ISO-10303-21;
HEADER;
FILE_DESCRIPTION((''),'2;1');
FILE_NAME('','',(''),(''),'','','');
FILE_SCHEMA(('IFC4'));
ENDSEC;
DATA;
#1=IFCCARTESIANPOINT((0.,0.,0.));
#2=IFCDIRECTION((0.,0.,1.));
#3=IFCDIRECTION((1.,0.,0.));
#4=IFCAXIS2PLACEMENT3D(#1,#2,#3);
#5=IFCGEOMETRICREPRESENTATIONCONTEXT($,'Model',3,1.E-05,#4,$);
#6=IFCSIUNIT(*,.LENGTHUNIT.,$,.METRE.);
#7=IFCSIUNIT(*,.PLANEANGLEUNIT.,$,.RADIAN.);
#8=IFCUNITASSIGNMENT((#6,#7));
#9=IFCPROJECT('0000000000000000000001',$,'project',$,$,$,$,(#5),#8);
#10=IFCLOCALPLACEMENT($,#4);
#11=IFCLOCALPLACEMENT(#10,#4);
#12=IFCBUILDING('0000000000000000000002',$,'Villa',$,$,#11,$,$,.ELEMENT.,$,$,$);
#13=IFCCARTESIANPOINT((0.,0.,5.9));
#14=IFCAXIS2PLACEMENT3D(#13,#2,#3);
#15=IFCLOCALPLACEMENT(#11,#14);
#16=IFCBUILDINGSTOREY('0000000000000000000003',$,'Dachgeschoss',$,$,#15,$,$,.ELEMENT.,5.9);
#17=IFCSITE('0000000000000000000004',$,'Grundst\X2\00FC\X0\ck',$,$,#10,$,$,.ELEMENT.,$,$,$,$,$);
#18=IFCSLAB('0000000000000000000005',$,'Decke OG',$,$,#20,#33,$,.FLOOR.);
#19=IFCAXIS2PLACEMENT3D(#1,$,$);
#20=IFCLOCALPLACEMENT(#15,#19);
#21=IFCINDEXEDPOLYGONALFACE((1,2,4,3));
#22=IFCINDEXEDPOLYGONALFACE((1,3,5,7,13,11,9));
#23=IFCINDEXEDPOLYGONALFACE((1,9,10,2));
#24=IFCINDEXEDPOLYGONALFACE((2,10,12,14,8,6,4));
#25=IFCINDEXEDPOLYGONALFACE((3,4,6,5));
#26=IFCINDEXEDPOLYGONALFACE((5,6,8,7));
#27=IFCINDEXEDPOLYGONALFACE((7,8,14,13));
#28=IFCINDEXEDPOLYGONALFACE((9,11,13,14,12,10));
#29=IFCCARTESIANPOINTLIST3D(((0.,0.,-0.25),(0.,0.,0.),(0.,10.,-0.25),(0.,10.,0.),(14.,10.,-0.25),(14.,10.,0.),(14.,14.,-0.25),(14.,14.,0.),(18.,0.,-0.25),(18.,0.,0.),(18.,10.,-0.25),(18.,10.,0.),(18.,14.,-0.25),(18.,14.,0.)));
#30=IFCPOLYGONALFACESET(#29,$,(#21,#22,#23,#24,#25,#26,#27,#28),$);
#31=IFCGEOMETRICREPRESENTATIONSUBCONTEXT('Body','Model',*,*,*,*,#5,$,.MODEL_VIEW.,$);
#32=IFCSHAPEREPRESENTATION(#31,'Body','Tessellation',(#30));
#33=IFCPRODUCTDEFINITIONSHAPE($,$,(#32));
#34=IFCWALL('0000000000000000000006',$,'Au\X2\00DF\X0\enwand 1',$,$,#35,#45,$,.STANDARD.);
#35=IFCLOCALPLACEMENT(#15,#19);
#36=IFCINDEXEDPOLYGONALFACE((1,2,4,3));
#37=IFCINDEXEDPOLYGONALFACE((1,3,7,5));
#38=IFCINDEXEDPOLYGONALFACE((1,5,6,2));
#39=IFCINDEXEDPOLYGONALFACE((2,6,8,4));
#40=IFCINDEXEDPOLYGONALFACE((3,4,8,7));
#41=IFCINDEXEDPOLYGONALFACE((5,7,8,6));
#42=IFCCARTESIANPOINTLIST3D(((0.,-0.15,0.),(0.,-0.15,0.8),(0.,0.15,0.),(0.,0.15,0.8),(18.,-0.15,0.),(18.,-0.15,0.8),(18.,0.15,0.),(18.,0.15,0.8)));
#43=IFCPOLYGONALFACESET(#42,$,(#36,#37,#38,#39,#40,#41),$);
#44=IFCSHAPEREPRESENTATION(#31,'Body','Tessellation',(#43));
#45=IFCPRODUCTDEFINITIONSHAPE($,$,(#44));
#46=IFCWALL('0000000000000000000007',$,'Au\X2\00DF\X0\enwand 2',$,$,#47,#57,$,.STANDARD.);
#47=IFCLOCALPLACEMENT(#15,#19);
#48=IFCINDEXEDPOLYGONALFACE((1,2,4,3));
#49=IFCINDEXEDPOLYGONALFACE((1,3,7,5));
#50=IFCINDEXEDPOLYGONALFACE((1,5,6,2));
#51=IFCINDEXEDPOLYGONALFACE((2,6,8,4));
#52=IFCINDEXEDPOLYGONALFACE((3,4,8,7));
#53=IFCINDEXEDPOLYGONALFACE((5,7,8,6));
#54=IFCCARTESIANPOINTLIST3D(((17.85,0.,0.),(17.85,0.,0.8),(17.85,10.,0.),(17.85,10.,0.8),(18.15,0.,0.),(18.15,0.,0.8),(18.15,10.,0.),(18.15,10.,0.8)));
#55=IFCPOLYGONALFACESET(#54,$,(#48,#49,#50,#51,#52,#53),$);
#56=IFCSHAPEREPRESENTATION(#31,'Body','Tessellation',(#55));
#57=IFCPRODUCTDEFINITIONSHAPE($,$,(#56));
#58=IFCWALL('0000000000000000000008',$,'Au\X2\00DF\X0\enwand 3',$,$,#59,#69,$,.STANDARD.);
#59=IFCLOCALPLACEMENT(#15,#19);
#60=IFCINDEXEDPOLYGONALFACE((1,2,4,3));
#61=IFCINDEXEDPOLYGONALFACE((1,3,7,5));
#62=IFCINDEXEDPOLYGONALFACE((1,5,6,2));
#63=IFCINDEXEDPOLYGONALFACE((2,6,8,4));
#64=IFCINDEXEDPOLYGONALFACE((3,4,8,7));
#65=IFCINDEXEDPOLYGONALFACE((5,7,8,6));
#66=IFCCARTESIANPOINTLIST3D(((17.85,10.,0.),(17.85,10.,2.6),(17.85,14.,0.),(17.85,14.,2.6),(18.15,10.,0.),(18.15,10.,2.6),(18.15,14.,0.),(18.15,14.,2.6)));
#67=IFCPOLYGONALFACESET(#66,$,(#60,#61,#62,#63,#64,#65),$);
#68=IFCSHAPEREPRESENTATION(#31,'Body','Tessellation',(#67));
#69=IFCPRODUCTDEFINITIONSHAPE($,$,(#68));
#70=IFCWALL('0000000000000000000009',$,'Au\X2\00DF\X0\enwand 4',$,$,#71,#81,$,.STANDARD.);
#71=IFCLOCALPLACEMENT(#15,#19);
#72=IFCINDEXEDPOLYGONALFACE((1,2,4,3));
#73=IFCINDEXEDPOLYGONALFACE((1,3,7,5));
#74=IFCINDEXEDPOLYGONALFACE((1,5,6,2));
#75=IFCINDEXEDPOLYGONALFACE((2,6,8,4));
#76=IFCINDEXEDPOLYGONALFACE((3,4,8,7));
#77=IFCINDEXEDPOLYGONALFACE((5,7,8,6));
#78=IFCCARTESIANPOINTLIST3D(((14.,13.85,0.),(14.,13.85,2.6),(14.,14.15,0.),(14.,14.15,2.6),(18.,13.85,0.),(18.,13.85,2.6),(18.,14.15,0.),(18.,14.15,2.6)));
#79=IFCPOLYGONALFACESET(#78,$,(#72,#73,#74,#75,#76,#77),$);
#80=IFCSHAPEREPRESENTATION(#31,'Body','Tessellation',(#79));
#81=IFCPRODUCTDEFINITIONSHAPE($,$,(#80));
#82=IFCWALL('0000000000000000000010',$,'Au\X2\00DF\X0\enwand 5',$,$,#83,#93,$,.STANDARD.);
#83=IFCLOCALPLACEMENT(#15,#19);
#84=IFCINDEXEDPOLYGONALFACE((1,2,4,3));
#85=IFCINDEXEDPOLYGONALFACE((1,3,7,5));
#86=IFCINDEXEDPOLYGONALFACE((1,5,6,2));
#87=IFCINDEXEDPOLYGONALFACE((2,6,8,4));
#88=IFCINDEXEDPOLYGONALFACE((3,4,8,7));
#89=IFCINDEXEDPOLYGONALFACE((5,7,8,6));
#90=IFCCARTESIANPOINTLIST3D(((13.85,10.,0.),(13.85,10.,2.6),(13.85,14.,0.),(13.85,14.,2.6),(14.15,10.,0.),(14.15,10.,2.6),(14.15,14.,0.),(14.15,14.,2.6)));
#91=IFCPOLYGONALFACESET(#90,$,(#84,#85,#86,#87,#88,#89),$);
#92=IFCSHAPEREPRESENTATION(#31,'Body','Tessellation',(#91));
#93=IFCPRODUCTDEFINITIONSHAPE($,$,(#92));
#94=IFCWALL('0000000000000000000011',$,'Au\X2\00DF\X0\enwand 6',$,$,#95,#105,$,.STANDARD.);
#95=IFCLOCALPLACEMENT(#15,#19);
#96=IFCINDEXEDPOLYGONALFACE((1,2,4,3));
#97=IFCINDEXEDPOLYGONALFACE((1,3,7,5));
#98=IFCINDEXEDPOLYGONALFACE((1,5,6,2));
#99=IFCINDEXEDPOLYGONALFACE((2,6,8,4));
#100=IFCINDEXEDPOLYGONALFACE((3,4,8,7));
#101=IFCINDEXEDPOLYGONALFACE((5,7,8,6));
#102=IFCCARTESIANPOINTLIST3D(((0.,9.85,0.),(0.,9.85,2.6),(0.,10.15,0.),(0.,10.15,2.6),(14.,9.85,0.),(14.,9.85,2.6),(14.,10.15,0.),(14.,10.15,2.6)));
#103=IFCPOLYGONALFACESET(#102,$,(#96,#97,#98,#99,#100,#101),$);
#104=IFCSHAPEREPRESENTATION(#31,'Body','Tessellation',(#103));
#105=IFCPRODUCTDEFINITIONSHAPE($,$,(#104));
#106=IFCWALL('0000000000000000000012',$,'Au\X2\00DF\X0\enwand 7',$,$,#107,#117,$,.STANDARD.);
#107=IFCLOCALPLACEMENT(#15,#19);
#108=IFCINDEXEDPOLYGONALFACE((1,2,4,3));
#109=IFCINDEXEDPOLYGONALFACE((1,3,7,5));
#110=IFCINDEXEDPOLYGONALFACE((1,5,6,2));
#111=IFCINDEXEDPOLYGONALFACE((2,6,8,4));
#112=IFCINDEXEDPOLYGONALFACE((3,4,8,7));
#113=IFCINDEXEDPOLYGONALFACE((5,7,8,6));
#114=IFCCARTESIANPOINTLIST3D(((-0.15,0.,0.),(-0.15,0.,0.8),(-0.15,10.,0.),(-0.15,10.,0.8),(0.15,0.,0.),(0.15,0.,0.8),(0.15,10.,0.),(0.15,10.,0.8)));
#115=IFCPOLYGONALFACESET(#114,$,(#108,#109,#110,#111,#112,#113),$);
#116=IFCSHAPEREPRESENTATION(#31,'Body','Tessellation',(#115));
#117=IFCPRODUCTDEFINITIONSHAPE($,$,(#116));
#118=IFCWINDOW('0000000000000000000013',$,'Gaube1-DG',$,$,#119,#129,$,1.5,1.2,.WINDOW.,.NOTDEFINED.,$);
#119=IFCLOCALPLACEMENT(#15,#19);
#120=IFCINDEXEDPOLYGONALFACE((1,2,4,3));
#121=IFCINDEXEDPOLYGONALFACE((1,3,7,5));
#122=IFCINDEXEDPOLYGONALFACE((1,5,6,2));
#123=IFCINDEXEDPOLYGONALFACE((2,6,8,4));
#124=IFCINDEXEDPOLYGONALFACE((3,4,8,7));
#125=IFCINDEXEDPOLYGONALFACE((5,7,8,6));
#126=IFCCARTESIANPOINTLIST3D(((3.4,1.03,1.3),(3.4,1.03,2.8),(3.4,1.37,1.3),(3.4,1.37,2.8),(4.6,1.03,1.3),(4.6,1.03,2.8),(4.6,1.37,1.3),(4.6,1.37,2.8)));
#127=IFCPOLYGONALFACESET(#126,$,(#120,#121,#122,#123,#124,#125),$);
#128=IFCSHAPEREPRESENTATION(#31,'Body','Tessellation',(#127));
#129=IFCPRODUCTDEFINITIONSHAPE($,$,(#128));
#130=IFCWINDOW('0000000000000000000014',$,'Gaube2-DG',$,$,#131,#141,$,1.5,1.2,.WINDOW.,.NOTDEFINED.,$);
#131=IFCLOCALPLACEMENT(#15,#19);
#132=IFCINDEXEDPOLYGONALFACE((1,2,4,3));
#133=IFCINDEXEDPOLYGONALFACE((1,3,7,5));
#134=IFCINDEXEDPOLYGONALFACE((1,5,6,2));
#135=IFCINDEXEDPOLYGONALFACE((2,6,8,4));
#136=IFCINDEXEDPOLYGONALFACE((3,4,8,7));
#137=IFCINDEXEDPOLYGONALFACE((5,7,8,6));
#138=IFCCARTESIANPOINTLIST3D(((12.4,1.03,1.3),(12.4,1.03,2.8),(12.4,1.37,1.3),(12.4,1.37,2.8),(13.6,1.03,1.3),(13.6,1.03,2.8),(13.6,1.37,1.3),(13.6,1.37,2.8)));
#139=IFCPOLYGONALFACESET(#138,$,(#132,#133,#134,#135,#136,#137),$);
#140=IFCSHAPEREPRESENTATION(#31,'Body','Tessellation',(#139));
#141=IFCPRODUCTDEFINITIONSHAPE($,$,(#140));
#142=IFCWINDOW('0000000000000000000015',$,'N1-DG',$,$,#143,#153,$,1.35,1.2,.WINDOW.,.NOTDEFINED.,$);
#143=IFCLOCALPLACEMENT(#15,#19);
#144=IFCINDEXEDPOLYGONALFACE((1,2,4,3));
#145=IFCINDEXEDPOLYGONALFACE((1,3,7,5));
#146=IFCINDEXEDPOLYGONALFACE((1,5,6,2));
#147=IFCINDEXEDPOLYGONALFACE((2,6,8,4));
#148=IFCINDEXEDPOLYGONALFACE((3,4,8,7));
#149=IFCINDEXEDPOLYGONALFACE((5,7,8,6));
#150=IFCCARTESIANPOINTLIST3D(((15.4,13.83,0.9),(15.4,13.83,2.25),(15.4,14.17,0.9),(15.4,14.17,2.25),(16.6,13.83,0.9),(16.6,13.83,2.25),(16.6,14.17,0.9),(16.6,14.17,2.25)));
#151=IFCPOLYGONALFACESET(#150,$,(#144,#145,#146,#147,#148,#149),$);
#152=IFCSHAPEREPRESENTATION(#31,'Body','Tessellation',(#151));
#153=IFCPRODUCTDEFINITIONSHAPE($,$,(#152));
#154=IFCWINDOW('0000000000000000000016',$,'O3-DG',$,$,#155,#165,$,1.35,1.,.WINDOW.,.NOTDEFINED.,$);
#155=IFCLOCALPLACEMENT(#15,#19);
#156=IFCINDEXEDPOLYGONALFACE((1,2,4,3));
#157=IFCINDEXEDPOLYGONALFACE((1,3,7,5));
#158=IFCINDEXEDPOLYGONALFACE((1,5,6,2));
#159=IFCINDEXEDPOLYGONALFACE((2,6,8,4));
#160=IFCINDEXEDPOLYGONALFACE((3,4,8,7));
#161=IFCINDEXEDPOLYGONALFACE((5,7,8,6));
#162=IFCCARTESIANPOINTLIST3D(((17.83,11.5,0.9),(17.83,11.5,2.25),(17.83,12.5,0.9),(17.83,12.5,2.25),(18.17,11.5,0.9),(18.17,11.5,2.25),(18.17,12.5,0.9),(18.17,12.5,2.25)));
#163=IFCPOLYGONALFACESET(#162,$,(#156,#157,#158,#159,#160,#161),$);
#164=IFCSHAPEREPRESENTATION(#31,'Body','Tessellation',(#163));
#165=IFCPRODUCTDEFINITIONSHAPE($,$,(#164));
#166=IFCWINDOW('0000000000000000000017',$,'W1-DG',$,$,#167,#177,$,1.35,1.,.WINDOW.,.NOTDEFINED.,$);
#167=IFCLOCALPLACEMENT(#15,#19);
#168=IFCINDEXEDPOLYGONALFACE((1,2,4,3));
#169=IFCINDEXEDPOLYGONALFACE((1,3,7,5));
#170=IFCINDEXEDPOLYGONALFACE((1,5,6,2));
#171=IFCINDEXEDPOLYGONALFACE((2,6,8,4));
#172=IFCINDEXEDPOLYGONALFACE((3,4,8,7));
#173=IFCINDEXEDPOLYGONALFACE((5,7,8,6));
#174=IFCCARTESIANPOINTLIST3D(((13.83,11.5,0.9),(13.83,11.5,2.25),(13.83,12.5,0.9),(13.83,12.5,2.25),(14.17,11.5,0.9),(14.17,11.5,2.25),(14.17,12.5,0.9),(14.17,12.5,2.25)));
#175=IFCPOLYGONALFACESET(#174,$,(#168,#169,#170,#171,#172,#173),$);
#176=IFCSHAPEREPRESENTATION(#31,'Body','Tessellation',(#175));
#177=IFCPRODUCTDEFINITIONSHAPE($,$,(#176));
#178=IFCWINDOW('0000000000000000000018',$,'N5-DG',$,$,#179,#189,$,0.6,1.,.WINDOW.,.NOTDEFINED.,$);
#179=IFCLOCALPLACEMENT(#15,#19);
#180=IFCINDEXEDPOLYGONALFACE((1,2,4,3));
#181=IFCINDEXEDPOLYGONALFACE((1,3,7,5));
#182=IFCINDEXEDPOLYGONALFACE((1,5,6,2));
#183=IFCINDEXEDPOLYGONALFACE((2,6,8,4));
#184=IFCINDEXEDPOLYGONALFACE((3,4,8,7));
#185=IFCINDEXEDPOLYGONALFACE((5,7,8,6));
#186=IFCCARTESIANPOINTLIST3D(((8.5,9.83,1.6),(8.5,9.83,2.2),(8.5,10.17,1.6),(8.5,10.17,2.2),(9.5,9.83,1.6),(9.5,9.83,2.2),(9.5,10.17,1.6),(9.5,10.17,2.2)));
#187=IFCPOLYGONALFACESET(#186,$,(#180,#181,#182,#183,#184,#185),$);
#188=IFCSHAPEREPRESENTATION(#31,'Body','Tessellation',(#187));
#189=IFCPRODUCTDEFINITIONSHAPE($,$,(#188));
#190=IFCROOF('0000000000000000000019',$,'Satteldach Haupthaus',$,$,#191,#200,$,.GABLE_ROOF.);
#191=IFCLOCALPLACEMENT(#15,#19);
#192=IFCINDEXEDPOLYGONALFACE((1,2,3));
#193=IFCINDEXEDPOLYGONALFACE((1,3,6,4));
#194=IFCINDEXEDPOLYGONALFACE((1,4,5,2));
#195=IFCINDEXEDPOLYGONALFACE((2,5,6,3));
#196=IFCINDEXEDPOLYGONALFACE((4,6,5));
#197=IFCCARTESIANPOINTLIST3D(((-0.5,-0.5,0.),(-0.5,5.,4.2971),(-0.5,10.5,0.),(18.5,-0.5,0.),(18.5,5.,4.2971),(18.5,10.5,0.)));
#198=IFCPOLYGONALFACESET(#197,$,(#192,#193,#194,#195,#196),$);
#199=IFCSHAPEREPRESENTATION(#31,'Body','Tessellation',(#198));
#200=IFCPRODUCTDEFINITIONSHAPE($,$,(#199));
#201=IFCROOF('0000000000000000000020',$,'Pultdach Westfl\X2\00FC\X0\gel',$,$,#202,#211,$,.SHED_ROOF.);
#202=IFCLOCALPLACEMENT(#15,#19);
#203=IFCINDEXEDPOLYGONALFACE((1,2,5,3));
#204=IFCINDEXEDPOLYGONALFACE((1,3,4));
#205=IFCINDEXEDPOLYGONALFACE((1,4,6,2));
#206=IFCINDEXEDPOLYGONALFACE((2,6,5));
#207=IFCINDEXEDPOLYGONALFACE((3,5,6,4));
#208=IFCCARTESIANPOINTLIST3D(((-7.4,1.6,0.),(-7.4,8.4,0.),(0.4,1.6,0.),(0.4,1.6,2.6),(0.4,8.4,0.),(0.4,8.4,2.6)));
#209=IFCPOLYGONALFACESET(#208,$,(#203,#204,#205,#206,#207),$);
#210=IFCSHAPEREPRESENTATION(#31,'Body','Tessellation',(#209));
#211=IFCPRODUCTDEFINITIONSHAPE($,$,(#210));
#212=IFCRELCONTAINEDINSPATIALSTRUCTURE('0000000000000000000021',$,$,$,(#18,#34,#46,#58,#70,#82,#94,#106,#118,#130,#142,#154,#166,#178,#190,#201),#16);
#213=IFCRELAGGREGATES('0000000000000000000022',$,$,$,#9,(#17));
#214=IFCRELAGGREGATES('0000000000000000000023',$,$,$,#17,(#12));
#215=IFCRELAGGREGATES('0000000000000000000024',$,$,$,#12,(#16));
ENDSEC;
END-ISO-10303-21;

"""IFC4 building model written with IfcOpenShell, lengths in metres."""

from ifc_helpers import new_model, si_unit, frame, frame_2d, origin_with_axes, origin_2d, place, context, subcontext, project, spatial, polyline, rectangle, outline, extrude, element, save


model = new_model("IFC4")

# Units and contexts
model_context = context("Model", 3, precision=1e-05, world=origin_with_axes())
body_context = subcontext(model_context, "Body", "Model", "MODEL_VIEW")
ifc_project = project(units=[si_unit("LENGTHUNIT", "METRE"), si_unit("PLANEANGLEUNIT", "RADIAN")], contexts=[model_context])

# Site, building, storey
site_placement = place(None, origin_with_axes())
site = spatial("IfcSite", under=ifc_project, at=site_placement, Name="Grundstück", CompositionType="ELEMENT")
building_placement = place(site_placement, origin_with_axes())
building = spatial("IfcBuilding", under=site, at=building_placement, Name="Villa", CompositionType="ELEMENT")
storey_placement = place(building_placement, frame((0.0, 0.0, 5.9), z_axis=(0.0, 0.0, 1.0), x_axis=(1.0, 0.0, 0.0)))
storey = spatial("IfcBuildingStorey", under=building, at=storey_placement, Name="Dachgeschoss", CompositionType="ELEMENT", Elevation=5.9)

# Slab
slab_placement = place(storey_placement, frame((0.0, 0.0, -0.25), z_axis=(0.0, 0.0, 1.0), x_axis=(1.0, 0.0, 0.0)))
element("IfcSlab", 1, at=slab_placement, inside=storey, Name="Decke OG", PredefinedType="FLOOR", context=body_context, shape_type="SweptSolid", body=[
    extrude(outline(polyline([(0.0, 0.0), (18.0, 0.0), (18.0, 10.0), (18.0, 14.0), (14.0, 14.0), (14.0, 10.0), (0.0, 10.0), (0.0, 0.0)])), origin_with_axes(), (0.0, 0.0, 1.0), 0.25),
])

# Walls
wall_1_placement = place(storey_placement, origin_with_axes())
element("IfcWall", 2, at=wall_1_placement, inside=storey, Name="Außenwand 1", PredefinedType="STANDARD", context=body_context, shape_type="SweptSolid", body=[
    extrude(rectangle(XDim=18.0, YDim=0.3, at=frame_2d((9.0, 0.0))), origin_with_axes(), (0.0, 0.0, 1.0), 0.8),
])
wall_2_placement = place(storey_placement, frame((18.0, 0.0, 0.0), z_axis=(0.0, 0.0, 1.0), x_axis=(0.0, 1.0, 0.0)))
element("IfcWall", 3, at=wall_2_placement, inside=storey, Name="Außenwand 2", PredefinedType="STANDARD", context=body_context, shape_type="SweptSolid", body=[
    extrude(rectangle(XDim=10.0, YDim=0.3, at=frame_2d((5.0, 0.0))), origin_with_axes(), (0.0, 0.0, 1.0), 0.8),
])
for number, where, z_axis, x_axis, name in (
    (4, (18.0, 10.0, 0.0), (0.0, 0.0, 1.0), (0.0, 1.0, 0.0), "Außenwand 3"),
    (5, (18.0, 14.0, 0.0), (0.0, 0.0, 1.0), (-1.0, 0.0, 0.0), "Außenwand 4"),
    (6, (14.0, 14.0, 0.0), (0.0, 0.0, 1.0), (0.0, -1.0, 0.0), "Außenwand 5"),
):
    element("IfcWall", number, at=place(storey_placement, frame(where, z_axis=z_axis, x_axis=x_axis)), inside=storey, Name=name, PredefinedType="STANDARD", context=body_context, shape_type="SweptSolid", body=[
        extrude(rectangle(XDim=4.0, YDim=0.3, at=frame_2d((2.0, 0.0))), origin_with_axes(), (0.0, 0.0, 1.0), 2.6),
    ])
wall_3_placement = place(storey_placement, frame((14.0, 10.0, 0.0), z_axis=(0.0, 0.0, 1.0), x_axis=(-1.0, 0.0, 0.0)))
element("IfcWall", 7, at=wall_3_placement, inside=storey, Name="Außenwand 6", PredefinedType="STANDARD", context=body_context, shape_type="SweptSolid", body=[
    extrude(rectangle(XDim=14.0, YDim=0.3, at=frame_2d((7.0, 0.0))), origin_with_axes(), (0.0, 0.0, 1.0), 2.6),
])
wall_4_placement = place(storey_placement, frame((0.0, 10.0, 0.0), z_axis=(0.0, 0.0, 1.0), x_axis=(0.0, -1.0, 0.0)))
element("IfcWall", 8, at=wall_4_placement, inside=storey, Name="Außenwand 7", PredefinedType="STANDARD", context=body_context, shape_type="SweptSolid", body=[
    extrude(rectangle(XDim=10.0, YDim=0.3, at=frame_2d((5.0, 0.0))), origin_with_axes(), (0.0, 0.0, 1.0), 0.8),
])

# Windows
for number, where, z_axis, x_axis, name in (
    (9, (4.0, 1.2, 1.3), (0.0, 0.0, 1.0), (1.0, 0.0, 0.0), "Gaube1-DG"),
    (10, (13.0, 1.2, 1.3), (0.0, 0.0, 1.0), (1.0, 0.0, 0.0), "Gaube2-DG"),
):
    element("IfcWindow", number, at=place(storey_placement, frame(where, z_axis=z_axis, x_axis=x_axis)), inside=storey, Name=name, OverallHeight=1.5, OverallWidth=1.2, PartitioningType="NOTDEFINED", PredefinedType="WINDOW", context=body_context, shape_type="SweptSolid", body=[
        extrude(rectangle(XDim=1.2, YDim=0.34, at=origin_2d()), origin_with_axes(), (0.0, 0.0, 1.0), 1.5),
    ])
window_1_placement = place(storey_placement, frame((16.0, 14.0, 0.9), z_axis=(0.0, 0.0, 1.0), x_axis=(1.0, 0.0, 0.0)))
element("IfcWindow", 11, at=window_1_placement, inside=storey, Name="N1-DG", OverallHeight=1.35, OverallWidth=1.2, PartitioningType="NOTDEFINED", PredefinedType="WINDOW", context=body_context, shape_type="SweptSolid", body=[
    extrude(rectangle(XDim=1.2, YDim=0.34, at=origin_2d()), origin_with_axes(), (0.0, 0.0, 1.0), 1.35),
])
for number, where, z_axis, x_axis, name in (
    (12, (18.0, 12.0, 0.9), (0.0, 0.0, 1.0), (0.0, 1.0, 0.0), "O3-DG"),
    (13, (14.0, 12.0, 0.9), (0.0, 0.0, 1.0), (0.0, 1.0, 0.0), "W1-DG"),
):
    element("IfcWindow", number, at=place(storey_placement, frame(where, z_axis=z_axis, x_axis=x_axis)), inside=storey, Name=name, OverallHeight=1.35, OverallWidth=1.0, PartitioningType="NOTDEFINED", PredefinedType="WINDOW", context=body_context, shape_type="SweptSolid", body=[
        extrude(rectangle(XDim=1.0, YDim=0.34, at=origin_2d()), origin_with_axes(), (0.0, 0.0, 1.0), 1.35),
    ])
window_2_placement = place(storey_placement, frame((9.0, 10.0, 1.6), z_axis=(0.0, 0.0, 1.0), x_axis=(1.0, 0.0, 0.0)))
element("IfcWindow", 14, at=window_2_placement, inside=storey, Name="N5-DG", OverallHeight=0.6, OverallWidth=1.0, PartitioningType="NOTDEFINED", PredefinedType="WINDOW", context=body_context, shape_type="SweptSolid", body=[
    extrude(rectangle(XDim=1.0, YDim=0.34, at=origin_2d()), origin_with_axes(), (0.0, 0.0, 1.0), 0.6),
])

# Roofs
roof_1_placement = place(building_placement, frame((-0.5, 0.0, 5.9), z_axis=(1.0, 0.0, 0.0), x_axis=(0.0, 1.0, 0.0)))
element("IfcRoof", 15, at=roof_1_placement, inside=storey, Name="Satteldach Haupthaus", PredefinedType="GABLE_ROOF", context=body_context, shape_type="SweptSolid", body=[
    extrude(outline(polyline([(-0.5, 0.0), (10.5, 0.0), (5.0, 4.2971), (-0.5, 0.0)])), origin_with_axes(), (0.0, 0.0, 1.0), 19.0),
])
roof_2_placement = place(building_placement, frame((0.0, 1.6, 5.9), z_axis=(0.0, 1.0, 0.0), x_axis=(-1.0, 0.0, 0.0)))
element("IfcRoof", 16, at=roof_2_placement, inside=storey, Name="Pultdach Westflügel", PredefinedType="SHED_ROOF", context=body_context, shape_type="SweptSolid", body=[
    extrude(outline(polyline([(-0.4, 0.0), (7.4, 0.0), (-0.4, 2.6), (-0.4, 0.0)])), origin_with_axes(), (0.0, 0.0, 1.0), 6.8),
])

save(model, "model.ifc")
